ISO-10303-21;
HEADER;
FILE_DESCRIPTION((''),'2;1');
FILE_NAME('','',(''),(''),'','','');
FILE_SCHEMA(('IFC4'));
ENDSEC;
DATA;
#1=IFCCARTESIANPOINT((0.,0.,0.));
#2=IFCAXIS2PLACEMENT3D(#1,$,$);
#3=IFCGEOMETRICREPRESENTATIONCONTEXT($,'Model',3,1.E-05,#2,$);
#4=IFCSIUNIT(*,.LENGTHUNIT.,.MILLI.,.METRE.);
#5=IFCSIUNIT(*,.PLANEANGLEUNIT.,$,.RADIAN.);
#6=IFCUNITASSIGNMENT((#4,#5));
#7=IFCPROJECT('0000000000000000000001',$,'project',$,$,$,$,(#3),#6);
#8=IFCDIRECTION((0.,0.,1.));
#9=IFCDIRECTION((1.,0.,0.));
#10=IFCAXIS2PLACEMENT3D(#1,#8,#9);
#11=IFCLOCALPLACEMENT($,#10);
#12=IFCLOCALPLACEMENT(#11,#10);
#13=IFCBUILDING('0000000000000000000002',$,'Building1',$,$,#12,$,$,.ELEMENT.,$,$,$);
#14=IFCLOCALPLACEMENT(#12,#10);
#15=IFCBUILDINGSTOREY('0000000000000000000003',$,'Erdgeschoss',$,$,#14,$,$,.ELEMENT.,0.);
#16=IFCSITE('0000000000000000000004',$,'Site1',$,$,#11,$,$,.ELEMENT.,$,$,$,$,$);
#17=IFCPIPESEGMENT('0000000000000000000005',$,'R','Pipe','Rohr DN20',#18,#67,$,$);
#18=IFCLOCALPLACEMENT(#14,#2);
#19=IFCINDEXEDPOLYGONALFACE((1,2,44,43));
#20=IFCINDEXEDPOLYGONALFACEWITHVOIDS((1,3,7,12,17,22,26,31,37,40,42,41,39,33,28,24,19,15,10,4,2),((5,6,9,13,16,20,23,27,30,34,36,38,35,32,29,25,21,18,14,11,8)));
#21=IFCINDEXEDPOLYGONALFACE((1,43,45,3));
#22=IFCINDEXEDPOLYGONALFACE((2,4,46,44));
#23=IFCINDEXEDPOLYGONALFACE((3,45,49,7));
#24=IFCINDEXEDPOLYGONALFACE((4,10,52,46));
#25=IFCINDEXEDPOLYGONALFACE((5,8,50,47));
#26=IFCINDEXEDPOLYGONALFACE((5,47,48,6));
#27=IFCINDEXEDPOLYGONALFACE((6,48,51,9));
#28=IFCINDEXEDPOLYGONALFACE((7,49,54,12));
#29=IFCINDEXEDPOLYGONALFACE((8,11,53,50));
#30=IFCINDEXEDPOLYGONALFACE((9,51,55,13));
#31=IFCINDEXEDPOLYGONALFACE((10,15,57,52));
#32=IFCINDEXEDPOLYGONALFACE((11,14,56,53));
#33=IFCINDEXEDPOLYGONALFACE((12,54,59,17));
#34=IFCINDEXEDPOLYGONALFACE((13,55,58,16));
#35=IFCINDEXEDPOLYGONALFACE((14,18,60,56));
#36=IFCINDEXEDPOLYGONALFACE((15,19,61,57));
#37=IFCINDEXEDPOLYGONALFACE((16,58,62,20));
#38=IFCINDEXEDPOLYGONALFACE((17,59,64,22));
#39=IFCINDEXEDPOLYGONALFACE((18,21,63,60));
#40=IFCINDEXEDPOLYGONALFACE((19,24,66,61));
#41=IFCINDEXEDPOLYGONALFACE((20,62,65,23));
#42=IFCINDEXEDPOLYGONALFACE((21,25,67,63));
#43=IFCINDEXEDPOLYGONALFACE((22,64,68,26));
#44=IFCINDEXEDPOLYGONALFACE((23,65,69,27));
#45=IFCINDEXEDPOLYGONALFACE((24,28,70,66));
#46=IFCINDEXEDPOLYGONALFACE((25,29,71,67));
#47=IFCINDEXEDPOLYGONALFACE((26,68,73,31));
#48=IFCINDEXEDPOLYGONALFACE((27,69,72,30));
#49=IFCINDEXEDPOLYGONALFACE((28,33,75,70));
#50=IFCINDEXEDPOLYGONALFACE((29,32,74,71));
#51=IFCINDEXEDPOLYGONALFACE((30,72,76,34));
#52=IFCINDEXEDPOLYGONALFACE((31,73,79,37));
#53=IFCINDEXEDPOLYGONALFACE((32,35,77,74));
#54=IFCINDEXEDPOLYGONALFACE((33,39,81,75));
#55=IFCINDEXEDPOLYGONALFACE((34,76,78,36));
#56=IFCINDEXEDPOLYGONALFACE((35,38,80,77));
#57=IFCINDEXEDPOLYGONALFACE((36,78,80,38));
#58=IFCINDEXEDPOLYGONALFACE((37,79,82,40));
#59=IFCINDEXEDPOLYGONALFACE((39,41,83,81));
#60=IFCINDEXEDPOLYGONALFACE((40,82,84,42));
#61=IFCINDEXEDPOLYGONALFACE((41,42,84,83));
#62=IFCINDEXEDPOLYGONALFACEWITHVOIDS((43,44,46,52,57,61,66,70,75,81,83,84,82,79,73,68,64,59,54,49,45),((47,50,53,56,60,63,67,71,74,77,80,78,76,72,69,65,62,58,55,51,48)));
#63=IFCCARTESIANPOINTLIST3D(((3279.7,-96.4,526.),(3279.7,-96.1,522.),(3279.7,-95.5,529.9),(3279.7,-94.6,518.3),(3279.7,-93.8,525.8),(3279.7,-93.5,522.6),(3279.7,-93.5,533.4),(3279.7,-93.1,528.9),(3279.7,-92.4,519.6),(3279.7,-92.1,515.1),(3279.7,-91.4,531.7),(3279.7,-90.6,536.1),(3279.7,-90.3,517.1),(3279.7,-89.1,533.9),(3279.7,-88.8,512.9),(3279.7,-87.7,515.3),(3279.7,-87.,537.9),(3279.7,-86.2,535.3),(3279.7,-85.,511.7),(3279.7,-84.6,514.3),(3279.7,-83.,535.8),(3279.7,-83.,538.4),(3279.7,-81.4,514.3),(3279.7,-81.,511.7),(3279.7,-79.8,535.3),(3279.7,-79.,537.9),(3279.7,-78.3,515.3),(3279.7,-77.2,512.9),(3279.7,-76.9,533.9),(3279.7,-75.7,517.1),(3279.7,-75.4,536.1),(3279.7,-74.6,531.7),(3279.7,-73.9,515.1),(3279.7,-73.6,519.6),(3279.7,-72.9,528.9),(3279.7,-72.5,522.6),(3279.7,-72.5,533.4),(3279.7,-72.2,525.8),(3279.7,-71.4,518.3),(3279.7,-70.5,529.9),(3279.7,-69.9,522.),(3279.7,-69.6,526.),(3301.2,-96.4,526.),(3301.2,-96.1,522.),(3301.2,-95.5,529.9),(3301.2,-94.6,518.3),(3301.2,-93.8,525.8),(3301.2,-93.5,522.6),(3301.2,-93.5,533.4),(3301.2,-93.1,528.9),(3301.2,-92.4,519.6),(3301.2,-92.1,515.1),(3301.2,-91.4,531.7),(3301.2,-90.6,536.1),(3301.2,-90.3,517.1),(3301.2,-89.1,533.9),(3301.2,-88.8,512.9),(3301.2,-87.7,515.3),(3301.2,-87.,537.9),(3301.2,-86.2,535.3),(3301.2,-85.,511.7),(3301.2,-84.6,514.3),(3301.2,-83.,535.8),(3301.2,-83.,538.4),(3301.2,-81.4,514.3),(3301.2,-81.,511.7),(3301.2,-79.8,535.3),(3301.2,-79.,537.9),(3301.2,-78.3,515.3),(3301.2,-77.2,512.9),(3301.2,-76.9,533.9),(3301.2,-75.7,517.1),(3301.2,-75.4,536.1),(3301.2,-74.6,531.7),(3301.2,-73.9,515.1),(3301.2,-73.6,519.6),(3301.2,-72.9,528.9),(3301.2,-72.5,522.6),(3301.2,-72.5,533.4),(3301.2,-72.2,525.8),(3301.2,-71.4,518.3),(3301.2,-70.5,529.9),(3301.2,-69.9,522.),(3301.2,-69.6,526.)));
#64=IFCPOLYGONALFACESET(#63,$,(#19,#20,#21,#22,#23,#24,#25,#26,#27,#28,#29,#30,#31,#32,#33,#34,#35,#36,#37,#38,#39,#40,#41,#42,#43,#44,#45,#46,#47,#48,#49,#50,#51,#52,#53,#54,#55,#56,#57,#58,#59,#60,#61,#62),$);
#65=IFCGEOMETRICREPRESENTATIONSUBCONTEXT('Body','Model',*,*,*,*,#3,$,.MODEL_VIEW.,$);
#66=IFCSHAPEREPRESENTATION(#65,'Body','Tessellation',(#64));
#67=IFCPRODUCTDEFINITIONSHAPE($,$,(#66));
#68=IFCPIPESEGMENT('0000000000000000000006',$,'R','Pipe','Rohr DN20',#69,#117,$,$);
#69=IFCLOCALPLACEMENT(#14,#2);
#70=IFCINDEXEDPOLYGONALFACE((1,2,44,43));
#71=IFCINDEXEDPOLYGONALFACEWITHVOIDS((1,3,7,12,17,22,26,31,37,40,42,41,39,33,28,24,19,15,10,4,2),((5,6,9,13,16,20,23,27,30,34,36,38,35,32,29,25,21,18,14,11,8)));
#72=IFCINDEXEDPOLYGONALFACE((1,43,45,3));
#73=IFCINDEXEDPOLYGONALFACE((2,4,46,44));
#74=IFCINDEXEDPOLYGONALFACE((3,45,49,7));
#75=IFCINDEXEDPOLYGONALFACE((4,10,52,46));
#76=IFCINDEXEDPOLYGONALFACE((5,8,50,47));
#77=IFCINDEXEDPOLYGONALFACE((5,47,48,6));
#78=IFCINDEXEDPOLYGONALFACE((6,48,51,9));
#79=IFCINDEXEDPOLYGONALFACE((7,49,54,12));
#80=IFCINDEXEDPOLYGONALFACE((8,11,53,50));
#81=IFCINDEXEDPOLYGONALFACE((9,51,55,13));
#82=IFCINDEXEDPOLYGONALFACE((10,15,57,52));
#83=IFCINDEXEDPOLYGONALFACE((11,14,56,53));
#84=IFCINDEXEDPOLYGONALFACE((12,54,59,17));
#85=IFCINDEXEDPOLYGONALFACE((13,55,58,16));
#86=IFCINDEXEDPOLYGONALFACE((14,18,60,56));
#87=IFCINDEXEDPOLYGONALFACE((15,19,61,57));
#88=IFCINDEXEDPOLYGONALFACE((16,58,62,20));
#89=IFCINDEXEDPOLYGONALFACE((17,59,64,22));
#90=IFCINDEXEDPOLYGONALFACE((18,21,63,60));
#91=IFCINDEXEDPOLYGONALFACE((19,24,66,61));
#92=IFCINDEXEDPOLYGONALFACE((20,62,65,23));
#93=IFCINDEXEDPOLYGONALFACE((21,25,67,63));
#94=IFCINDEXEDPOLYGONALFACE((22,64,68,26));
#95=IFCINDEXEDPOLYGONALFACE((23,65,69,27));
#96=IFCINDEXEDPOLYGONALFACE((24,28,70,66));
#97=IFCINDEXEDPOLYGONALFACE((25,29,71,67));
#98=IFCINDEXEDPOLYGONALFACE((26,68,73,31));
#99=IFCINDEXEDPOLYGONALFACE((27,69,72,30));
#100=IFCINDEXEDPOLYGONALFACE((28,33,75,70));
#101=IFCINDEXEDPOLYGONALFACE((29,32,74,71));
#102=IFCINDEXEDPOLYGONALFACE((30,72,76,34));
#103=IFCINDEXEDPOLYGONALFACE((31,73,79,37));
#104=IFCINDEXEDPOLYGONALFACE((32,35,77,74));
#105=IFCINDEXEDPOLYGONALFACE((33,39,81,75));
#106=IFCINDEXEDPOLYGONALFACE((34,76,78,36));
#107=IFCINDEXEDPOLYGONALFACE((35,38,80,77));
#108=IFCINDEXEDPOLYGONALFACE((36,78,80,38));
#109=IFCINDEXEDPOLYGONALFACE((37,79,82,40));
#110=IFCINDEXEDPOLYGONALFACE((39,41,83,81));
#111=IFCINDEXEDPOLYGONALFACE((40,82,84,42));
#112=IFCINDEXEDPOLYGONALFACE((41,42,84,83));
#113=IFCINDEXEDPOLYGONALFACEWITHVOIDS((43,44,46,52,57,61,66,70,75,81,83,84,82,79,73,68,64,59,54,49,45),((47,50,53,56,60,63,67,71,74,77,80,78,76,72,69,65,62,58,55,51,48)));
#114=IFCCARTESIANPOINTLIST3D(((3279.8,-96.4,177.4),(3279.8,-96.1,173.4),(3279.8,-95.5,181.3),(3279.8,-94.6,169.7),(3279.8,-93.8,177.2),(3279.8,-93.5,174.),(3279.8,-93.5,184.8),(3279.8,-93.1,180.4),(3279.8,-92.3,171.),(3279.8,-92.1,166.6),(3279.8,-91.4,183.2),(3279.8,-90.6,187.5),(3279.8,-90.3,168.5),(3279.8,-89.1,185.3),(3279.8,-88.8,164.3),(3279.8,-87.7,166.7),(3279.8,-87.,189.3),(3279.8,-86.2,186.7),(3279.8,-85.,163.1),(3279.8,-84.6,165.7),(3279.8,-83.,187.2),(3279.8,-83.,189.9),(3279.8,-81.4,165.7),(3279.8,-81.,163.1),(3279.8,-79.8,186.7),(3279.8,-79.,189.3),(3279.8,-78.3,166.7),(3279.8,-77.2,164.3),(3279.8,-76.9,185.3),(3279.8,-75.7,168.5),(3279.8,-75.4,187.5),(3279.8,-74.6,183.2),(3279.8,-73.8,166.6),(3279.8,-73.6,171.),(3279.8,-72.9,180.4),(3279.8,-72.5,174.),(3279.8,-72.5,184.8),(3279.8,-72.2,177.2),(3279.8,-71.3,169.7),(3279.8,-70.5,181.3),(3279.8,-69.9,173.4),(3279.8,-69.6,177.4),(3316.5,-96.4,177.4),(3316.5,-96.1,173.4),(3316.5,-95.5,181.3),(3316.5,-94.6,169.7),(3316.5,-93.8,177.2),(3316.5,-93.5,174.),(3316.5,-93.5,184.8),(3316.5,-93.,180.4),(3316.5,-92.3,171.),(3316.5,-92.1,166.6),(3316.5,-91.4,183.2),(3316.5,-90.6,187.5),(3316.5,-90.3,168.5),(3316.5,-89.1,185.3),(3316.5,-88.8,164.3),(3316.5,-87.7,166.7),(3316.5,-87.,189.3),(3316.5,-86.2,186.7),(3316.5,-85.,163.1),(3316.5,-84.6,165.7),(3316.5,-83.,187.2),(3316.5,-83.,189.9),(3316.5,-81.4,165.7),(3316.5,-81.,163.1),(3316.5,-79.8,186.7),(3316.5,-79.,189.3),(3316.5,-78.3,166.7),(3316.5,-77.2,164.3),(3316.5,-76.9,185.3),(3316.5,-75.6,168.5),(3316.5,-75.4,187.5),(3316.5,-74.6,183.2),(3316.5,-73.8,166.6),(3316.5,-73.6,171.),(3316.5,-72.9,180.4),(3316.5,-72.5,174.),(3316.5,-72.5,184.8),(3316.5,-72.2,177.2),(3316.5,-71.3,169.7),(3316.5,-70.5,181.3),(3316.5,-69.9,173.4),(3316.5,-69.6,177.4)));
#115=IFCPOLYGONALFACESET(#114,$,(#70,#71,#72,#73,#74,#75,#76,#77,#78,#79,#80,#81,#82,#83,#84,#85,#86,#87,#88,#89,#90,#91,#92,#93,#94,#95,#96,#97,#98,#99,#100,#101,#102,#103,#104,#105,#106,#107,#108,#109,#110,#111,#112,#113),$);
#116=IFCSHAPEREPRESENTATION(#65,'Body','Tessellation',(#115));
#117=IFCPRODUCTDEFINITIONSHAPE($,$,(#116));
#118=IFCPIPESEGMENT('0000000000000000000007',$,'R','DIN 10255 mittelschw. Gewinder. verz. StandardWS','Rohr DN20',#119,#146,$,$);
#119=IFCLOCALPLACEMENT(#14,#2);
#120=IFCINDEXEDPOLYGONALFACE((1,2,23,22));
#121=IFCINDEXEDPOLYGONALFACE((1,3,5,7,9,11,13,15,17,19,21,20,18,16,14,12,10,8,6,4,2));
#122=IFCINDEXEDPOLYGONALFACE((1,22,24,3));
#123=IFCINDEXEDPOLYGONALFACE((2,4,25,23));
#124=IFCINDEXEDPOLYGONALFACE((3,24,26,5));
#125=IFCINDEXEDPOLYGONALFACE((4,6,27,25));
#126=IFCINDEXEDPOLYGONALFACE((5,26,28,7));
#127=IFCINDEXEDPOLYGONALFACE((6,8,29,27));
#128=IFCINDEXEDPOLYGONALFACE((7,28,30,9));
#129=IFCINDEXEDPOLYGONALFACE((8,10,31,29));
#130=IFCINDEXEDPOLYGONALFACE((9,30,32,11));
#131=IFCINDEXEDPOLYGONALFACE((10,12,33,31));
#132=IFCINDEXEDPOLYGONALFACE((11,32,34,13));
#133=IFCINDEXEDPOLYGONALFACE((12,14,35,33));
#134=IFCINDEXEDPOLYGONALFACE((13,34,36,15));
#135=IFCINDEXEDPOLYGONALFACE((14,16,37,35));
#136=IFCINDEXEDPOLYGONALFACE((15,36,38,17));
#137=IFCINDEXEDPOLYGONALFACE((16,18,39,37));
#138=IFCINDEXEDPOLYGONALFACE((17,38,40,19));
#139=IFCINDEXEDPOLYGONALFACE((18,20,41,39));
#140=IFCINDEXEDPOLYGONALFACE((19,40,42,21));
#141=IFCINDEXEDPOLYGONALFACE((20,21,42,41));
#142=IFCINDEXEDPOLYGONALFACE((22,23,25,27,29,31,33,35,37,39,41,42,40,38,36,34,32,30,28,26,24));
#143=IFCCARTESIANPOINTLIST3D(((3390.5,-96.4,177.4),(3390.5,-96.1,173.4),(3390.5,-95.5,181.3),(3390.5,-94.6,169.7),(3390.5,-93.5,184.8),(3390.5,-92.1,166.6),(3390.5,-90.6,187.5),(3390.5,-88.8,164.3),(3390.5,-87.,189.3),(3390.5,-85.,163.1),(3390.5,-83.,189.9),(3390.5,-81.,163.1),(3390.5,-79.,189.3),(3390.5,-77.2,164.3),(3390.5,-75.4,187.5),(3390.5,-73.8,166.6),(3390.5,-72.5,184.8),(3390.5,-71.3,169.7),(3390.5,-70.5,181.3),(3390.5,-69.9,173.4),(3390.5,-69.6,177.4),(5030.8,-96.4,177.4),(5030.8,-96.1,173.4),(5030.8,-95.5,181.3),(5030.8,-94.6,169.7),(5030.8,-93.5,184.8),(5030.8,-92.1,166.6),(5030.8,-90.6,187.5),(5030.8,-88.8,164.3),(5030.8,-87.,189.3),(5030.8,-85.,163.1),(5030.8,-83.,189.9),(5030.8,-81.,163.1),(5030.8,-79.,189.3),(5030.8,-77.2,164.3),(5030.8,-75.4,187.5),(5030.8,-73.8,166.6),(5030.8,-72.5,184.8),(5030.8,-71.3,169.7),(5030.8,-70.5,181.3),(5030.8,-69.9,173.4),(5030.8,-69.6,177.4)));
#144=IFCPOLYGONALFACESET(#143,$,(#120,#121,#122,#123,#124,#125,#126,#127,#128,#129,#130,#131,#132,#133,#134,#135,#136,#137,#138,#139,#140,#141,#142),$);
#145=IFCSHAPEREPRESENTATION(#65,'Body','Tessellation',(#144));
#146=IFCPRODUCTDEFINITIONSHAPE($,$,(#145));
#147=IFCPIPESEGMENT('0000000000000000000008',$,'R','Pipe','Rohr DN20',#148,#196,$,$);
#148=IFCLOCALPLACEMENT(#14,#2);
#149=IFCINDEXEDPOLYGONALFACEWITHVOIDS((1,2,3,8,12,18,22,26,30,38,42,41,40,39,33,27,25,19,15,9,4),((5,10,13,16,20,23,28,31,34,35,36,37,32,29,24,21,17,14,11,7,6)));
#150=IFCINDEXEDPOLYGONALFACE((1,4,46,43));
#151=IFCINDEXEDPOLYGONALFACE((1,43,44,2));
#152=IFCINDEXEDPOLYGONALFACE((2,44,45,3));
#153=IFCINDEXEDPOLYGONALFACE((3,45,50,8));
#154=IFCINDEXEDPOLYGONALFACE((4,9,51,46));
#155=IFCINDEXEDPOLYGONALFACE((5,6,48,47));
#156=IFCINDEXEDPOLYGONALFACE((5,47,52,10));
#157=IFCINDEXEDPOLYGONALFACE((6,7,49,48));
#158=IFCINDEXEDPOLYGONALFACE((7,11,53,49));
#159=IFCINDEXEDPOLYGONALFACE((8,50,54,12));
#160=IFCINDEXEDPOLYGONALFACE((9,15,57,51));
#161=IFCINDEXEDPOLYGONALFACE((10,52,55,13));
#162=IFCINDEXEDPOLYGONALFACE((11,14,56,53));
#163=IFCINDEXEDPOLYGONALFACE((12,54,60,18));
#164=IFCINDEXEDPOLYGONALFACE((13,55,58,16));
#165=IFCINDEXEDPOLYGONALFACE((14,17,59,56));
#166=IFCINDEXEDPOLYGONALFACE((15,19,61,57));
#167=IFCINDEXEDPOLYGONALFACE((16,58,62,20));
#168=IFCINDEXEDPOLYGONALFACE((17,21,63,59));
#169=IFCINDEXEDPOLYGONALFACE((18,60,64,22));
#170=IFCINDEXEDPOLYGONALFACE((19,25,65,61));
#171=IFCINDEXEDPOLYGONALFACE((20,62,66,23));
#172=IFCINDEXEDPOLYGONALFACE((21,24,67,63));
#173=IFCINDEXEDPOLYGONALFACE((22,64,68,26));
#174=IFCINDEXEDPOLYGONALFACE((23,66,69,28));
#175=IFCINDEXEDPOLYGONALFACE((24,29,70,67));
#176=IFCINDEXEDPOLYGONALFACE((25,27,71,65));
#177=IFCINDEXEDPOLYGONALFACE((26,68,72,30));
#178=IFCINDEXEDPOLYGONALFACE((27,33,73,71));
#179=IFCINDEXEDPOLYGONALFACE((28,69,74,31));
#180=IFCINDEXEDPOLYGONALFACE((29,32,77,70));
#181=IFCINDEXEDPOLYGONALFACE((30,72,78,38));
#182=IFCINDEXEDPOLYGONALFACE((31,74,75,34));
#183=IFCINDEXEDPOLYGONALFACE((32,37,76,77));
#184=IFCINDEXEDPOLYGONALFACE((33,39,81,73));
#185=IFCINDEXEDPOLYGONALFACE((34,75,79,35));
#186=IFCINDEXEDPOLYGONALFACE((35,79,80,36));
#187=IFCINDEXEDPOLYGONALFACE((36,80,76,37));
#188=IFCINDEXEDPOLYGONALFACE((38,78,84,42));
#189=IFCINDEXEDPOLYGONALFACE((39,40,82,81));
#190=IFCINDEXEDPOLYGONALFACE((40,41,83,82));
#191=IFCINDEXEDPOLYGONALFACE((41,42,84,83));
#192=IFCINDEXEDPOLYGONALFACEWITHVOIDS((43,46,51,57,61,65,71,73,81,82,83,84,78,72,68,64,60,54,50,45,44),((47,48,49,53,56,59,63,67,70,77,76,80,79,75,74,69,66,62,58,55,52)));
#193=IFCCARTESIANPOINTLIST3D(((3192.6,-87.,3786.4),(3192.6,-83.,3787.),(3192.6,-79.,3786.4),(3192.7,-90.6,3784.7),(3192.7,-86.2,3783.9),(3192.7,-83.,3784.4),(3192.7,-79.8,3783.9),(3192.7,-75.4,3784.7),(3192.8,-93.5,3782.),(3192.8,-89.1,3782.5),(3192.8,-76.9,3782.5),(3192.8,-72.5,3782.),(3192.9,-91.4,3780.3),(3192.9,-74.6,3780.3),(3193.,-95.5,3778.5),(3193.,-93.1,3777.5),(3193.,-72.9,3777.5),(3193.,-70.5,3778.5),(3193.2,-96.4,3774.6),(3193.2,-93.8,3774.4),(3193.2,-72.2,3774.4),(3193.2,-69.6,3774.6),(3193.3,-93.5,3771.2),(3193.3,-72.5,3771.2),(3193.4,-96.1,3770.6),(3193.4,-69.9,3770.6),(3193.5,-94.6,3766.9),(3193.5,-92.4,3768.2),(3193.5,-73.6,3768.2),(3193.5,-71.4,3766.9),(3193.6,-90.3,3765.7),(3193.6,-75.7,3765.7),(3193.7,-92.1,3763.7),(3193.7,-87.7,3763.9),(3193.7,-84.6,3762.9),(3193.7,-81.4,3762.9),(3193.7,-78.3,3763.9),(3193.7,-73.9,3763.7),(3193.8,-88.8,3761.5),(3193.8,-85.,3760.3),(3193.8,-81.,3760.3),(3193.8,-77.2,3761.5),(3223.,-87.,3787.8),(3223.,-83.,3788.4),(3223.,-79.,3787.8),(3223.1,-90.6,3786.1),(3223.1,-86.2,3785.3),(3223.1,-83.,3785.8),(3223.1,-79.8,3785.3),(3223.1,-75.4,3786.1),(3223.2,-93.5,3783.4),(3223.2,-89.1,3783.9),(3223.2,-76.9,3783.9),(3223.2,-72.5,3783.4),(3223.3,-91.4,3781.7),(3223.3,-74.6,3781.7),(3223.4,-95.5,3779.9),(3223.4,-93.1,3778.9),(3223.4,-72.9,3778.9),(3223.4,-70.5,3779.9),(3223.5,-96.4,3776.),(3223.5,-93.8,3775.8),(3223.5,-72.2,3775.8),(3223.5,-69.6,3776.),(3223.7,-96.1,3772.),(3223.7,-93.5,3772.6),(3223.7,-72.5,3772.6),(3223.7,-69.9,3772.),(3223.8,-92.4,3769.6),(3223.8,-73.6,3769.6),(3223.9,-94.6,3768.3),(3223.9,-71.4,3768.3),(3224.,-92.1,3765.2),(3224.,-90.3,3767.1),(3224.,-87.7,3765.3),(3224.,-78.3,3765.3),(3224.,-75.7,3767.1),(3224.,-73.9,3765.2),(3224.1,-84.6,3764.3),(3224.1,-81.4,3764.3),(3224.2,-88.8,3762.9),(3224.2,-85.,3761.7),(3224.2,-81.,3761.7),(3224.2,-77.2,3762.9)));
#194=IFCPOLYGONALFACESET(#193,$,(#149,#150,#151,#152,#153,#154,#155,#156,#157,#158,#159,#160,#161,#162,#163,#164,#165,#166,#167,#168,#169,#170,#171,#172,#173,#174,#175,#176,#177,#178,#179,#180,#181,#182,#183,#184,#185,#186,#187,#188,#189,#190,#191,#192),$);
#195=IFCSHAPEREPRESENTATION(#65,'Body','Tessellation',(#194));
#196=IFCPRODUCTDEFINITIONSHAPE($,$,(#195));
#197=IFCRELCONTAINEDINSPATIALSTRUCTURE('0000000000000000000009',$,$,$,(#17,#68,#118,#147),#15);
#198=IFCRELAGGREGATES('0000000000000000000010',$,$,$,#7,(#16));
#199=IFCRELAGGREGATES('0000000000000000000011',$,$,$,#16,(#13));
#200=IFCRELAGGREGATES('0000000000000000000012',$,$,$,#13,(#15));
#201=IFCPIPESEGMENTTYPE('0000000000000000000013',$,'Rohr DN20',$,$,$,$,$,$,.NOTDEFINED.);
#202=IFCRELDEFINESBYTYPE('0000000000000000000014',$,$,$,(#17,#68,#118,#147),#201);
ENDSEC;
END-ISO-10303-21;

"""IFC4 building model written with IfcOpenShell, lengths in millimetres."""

from ifc_helpers import new_model, si_unit, frame, origin, origin_with_axes, origin_2d_with_axis, place, context, subcontext, project, spatial, circle, hollow_circle, extrude, type_object, element, save


model = new_model("IFC4")

# Units and contexts
model_context = context("Model", 3, precision=1e-05, world=origin())
body_context = subcontext(model_context, "Body", "Model", "MODEL_VIEW")
ifc_project = project(units=[si_unit("LENGTHUNIT", "METRE", prefix="MILLI"), si_unit("PLANEANGLEUNIT", "RADIAN")], contexts=[model_context])

# Site, building, storey
site_placement = place(None, origin_with_axes())
site = spatial("IfcSite", under=ifc_project, at=site_placement, Name="Site1", CompositionType="ELEMENT")
building_placement = place(site_placement, origin_with_axes())
building = spatial("IfcBuilding", under=site, at=building_placement, Name="Building1", CompositionType="ELEMENT")
storey_placement = place(building_placement, origin_with_axes())
storey = spatial("IfcBuildingStorey", under=building, at=storey_placement, Name="Erdgeschoss", CompositionType="ELEMENT", Elevation=0.0)

# Pipe segments
pipe_segment_type_1 = type_object("IfcPipeSegmentType", Name="Rohr DN20", PredefinedType="NOTDEFINED")
pipe_segment_1_placement = place(storey_placement, frame((3290.5, -82.8, 525.0), z_axis=(0.0, 0.0, 1.0), x_axis=(1.0, 0.0, 0.0)))
element("IfcPipeSegment", 1, at=pipe_segment_1_placement, inside=storey, type_object=pipe_segment_type_1, Name="R", Description="Pipe", ObjectType="Rohr DN20", context=body_context, shape_type="SolidModel", body=[
    extrude(hollow_circle(Radius=13.4, WallThickness=2.6, at=origin_2d_with_axis()), frame((-10.8, -0.1, 0.0), z_axis=(1.0, 0.0, 0.000043), x_axis=(0.0, 0.0, 1.0)), (0.0, 0.0, 1.0), 21.5),
])
pipe_segment_2_placement = place(storey_placement, frame((3298.1, -82.8, 176.4), z_axis=(0.0, 0.0, 1.0), x_axis=(1.0, 0.0, 0.0)))
element("IfcPipeSegment", 2, at=pipe_segment_2_placement, inside=storey, type_object=pipe_segment_type_1, Name="R", Description="Pipe", ObjectType="Rohr DN20", context=body_context, shape_type="SolidModel", body=[
    extrude(hollow_circle(Radius=13.4, WallThickness=2.6, at=origin_2d_with_axis()), frame((-18.4, -0.2, 0.0), z_axis=(1.0, 0.000064, -0.000089), x_axis=(0.0, 0.0, 1.0)), (0.0, 0.0, 1.0), 36.7),
])
pipe_segment_3_placement = place(storey_placement, frame((4210.6, -83.1, 176.4), z_axis=(0.0, 0.0, 1.0), x_axis=(1.0, 0.0, 0.0)))
element("IfcPipeSegment", 3, at=pipe_segment_3_placement, inside=storey, type_object=pipe_segment_type_1, Name="R", Description="DIN 10255 mittelschw. Gewinder. verz. StandardWS", ObjectType="Rohr DN20", context=body_context, shape_type="SolidModel", body=[
    extrude(circle(Radius=13.4, at=origin_2d_with_axis()), frame((820.1, 0.1, 0.0), z_axis=(-1.0, 0.000001, -0.000002), x_axis=(0.0, 0.0, 1.0)), (0.0, 0.0, 1.0), 1640.3),
])
pipe_segment_4_placement = place(storey_placement, frame((3208.4, -82.8, 3774.3), z_axis=(0.0, 0.0, 1.0), x_axis=(1.0, 0.0, 0.0)))
element("IfcPipeSegment", 4, at=pipe_segment_4_placement, inside=storey, type_object=pipe_segment_type_1, Name="R", Description="Pipe", ObjectType="Rohr DN20", context=body_context, shape_type="SolidModel", body=[
    extrude(hollow_circle(Radius=13.4, WallThickness=2.6, at=origin_2d_with_axis()), frame((-15.2, -0.1, -0.7), z_axis=(0.998901, 0.0, 0.046868), x_axis=(0.0, 0.0, 1.0)), (0.0, 0.0, 1.0), 30.4),
])

save(model, "model.ifc")
